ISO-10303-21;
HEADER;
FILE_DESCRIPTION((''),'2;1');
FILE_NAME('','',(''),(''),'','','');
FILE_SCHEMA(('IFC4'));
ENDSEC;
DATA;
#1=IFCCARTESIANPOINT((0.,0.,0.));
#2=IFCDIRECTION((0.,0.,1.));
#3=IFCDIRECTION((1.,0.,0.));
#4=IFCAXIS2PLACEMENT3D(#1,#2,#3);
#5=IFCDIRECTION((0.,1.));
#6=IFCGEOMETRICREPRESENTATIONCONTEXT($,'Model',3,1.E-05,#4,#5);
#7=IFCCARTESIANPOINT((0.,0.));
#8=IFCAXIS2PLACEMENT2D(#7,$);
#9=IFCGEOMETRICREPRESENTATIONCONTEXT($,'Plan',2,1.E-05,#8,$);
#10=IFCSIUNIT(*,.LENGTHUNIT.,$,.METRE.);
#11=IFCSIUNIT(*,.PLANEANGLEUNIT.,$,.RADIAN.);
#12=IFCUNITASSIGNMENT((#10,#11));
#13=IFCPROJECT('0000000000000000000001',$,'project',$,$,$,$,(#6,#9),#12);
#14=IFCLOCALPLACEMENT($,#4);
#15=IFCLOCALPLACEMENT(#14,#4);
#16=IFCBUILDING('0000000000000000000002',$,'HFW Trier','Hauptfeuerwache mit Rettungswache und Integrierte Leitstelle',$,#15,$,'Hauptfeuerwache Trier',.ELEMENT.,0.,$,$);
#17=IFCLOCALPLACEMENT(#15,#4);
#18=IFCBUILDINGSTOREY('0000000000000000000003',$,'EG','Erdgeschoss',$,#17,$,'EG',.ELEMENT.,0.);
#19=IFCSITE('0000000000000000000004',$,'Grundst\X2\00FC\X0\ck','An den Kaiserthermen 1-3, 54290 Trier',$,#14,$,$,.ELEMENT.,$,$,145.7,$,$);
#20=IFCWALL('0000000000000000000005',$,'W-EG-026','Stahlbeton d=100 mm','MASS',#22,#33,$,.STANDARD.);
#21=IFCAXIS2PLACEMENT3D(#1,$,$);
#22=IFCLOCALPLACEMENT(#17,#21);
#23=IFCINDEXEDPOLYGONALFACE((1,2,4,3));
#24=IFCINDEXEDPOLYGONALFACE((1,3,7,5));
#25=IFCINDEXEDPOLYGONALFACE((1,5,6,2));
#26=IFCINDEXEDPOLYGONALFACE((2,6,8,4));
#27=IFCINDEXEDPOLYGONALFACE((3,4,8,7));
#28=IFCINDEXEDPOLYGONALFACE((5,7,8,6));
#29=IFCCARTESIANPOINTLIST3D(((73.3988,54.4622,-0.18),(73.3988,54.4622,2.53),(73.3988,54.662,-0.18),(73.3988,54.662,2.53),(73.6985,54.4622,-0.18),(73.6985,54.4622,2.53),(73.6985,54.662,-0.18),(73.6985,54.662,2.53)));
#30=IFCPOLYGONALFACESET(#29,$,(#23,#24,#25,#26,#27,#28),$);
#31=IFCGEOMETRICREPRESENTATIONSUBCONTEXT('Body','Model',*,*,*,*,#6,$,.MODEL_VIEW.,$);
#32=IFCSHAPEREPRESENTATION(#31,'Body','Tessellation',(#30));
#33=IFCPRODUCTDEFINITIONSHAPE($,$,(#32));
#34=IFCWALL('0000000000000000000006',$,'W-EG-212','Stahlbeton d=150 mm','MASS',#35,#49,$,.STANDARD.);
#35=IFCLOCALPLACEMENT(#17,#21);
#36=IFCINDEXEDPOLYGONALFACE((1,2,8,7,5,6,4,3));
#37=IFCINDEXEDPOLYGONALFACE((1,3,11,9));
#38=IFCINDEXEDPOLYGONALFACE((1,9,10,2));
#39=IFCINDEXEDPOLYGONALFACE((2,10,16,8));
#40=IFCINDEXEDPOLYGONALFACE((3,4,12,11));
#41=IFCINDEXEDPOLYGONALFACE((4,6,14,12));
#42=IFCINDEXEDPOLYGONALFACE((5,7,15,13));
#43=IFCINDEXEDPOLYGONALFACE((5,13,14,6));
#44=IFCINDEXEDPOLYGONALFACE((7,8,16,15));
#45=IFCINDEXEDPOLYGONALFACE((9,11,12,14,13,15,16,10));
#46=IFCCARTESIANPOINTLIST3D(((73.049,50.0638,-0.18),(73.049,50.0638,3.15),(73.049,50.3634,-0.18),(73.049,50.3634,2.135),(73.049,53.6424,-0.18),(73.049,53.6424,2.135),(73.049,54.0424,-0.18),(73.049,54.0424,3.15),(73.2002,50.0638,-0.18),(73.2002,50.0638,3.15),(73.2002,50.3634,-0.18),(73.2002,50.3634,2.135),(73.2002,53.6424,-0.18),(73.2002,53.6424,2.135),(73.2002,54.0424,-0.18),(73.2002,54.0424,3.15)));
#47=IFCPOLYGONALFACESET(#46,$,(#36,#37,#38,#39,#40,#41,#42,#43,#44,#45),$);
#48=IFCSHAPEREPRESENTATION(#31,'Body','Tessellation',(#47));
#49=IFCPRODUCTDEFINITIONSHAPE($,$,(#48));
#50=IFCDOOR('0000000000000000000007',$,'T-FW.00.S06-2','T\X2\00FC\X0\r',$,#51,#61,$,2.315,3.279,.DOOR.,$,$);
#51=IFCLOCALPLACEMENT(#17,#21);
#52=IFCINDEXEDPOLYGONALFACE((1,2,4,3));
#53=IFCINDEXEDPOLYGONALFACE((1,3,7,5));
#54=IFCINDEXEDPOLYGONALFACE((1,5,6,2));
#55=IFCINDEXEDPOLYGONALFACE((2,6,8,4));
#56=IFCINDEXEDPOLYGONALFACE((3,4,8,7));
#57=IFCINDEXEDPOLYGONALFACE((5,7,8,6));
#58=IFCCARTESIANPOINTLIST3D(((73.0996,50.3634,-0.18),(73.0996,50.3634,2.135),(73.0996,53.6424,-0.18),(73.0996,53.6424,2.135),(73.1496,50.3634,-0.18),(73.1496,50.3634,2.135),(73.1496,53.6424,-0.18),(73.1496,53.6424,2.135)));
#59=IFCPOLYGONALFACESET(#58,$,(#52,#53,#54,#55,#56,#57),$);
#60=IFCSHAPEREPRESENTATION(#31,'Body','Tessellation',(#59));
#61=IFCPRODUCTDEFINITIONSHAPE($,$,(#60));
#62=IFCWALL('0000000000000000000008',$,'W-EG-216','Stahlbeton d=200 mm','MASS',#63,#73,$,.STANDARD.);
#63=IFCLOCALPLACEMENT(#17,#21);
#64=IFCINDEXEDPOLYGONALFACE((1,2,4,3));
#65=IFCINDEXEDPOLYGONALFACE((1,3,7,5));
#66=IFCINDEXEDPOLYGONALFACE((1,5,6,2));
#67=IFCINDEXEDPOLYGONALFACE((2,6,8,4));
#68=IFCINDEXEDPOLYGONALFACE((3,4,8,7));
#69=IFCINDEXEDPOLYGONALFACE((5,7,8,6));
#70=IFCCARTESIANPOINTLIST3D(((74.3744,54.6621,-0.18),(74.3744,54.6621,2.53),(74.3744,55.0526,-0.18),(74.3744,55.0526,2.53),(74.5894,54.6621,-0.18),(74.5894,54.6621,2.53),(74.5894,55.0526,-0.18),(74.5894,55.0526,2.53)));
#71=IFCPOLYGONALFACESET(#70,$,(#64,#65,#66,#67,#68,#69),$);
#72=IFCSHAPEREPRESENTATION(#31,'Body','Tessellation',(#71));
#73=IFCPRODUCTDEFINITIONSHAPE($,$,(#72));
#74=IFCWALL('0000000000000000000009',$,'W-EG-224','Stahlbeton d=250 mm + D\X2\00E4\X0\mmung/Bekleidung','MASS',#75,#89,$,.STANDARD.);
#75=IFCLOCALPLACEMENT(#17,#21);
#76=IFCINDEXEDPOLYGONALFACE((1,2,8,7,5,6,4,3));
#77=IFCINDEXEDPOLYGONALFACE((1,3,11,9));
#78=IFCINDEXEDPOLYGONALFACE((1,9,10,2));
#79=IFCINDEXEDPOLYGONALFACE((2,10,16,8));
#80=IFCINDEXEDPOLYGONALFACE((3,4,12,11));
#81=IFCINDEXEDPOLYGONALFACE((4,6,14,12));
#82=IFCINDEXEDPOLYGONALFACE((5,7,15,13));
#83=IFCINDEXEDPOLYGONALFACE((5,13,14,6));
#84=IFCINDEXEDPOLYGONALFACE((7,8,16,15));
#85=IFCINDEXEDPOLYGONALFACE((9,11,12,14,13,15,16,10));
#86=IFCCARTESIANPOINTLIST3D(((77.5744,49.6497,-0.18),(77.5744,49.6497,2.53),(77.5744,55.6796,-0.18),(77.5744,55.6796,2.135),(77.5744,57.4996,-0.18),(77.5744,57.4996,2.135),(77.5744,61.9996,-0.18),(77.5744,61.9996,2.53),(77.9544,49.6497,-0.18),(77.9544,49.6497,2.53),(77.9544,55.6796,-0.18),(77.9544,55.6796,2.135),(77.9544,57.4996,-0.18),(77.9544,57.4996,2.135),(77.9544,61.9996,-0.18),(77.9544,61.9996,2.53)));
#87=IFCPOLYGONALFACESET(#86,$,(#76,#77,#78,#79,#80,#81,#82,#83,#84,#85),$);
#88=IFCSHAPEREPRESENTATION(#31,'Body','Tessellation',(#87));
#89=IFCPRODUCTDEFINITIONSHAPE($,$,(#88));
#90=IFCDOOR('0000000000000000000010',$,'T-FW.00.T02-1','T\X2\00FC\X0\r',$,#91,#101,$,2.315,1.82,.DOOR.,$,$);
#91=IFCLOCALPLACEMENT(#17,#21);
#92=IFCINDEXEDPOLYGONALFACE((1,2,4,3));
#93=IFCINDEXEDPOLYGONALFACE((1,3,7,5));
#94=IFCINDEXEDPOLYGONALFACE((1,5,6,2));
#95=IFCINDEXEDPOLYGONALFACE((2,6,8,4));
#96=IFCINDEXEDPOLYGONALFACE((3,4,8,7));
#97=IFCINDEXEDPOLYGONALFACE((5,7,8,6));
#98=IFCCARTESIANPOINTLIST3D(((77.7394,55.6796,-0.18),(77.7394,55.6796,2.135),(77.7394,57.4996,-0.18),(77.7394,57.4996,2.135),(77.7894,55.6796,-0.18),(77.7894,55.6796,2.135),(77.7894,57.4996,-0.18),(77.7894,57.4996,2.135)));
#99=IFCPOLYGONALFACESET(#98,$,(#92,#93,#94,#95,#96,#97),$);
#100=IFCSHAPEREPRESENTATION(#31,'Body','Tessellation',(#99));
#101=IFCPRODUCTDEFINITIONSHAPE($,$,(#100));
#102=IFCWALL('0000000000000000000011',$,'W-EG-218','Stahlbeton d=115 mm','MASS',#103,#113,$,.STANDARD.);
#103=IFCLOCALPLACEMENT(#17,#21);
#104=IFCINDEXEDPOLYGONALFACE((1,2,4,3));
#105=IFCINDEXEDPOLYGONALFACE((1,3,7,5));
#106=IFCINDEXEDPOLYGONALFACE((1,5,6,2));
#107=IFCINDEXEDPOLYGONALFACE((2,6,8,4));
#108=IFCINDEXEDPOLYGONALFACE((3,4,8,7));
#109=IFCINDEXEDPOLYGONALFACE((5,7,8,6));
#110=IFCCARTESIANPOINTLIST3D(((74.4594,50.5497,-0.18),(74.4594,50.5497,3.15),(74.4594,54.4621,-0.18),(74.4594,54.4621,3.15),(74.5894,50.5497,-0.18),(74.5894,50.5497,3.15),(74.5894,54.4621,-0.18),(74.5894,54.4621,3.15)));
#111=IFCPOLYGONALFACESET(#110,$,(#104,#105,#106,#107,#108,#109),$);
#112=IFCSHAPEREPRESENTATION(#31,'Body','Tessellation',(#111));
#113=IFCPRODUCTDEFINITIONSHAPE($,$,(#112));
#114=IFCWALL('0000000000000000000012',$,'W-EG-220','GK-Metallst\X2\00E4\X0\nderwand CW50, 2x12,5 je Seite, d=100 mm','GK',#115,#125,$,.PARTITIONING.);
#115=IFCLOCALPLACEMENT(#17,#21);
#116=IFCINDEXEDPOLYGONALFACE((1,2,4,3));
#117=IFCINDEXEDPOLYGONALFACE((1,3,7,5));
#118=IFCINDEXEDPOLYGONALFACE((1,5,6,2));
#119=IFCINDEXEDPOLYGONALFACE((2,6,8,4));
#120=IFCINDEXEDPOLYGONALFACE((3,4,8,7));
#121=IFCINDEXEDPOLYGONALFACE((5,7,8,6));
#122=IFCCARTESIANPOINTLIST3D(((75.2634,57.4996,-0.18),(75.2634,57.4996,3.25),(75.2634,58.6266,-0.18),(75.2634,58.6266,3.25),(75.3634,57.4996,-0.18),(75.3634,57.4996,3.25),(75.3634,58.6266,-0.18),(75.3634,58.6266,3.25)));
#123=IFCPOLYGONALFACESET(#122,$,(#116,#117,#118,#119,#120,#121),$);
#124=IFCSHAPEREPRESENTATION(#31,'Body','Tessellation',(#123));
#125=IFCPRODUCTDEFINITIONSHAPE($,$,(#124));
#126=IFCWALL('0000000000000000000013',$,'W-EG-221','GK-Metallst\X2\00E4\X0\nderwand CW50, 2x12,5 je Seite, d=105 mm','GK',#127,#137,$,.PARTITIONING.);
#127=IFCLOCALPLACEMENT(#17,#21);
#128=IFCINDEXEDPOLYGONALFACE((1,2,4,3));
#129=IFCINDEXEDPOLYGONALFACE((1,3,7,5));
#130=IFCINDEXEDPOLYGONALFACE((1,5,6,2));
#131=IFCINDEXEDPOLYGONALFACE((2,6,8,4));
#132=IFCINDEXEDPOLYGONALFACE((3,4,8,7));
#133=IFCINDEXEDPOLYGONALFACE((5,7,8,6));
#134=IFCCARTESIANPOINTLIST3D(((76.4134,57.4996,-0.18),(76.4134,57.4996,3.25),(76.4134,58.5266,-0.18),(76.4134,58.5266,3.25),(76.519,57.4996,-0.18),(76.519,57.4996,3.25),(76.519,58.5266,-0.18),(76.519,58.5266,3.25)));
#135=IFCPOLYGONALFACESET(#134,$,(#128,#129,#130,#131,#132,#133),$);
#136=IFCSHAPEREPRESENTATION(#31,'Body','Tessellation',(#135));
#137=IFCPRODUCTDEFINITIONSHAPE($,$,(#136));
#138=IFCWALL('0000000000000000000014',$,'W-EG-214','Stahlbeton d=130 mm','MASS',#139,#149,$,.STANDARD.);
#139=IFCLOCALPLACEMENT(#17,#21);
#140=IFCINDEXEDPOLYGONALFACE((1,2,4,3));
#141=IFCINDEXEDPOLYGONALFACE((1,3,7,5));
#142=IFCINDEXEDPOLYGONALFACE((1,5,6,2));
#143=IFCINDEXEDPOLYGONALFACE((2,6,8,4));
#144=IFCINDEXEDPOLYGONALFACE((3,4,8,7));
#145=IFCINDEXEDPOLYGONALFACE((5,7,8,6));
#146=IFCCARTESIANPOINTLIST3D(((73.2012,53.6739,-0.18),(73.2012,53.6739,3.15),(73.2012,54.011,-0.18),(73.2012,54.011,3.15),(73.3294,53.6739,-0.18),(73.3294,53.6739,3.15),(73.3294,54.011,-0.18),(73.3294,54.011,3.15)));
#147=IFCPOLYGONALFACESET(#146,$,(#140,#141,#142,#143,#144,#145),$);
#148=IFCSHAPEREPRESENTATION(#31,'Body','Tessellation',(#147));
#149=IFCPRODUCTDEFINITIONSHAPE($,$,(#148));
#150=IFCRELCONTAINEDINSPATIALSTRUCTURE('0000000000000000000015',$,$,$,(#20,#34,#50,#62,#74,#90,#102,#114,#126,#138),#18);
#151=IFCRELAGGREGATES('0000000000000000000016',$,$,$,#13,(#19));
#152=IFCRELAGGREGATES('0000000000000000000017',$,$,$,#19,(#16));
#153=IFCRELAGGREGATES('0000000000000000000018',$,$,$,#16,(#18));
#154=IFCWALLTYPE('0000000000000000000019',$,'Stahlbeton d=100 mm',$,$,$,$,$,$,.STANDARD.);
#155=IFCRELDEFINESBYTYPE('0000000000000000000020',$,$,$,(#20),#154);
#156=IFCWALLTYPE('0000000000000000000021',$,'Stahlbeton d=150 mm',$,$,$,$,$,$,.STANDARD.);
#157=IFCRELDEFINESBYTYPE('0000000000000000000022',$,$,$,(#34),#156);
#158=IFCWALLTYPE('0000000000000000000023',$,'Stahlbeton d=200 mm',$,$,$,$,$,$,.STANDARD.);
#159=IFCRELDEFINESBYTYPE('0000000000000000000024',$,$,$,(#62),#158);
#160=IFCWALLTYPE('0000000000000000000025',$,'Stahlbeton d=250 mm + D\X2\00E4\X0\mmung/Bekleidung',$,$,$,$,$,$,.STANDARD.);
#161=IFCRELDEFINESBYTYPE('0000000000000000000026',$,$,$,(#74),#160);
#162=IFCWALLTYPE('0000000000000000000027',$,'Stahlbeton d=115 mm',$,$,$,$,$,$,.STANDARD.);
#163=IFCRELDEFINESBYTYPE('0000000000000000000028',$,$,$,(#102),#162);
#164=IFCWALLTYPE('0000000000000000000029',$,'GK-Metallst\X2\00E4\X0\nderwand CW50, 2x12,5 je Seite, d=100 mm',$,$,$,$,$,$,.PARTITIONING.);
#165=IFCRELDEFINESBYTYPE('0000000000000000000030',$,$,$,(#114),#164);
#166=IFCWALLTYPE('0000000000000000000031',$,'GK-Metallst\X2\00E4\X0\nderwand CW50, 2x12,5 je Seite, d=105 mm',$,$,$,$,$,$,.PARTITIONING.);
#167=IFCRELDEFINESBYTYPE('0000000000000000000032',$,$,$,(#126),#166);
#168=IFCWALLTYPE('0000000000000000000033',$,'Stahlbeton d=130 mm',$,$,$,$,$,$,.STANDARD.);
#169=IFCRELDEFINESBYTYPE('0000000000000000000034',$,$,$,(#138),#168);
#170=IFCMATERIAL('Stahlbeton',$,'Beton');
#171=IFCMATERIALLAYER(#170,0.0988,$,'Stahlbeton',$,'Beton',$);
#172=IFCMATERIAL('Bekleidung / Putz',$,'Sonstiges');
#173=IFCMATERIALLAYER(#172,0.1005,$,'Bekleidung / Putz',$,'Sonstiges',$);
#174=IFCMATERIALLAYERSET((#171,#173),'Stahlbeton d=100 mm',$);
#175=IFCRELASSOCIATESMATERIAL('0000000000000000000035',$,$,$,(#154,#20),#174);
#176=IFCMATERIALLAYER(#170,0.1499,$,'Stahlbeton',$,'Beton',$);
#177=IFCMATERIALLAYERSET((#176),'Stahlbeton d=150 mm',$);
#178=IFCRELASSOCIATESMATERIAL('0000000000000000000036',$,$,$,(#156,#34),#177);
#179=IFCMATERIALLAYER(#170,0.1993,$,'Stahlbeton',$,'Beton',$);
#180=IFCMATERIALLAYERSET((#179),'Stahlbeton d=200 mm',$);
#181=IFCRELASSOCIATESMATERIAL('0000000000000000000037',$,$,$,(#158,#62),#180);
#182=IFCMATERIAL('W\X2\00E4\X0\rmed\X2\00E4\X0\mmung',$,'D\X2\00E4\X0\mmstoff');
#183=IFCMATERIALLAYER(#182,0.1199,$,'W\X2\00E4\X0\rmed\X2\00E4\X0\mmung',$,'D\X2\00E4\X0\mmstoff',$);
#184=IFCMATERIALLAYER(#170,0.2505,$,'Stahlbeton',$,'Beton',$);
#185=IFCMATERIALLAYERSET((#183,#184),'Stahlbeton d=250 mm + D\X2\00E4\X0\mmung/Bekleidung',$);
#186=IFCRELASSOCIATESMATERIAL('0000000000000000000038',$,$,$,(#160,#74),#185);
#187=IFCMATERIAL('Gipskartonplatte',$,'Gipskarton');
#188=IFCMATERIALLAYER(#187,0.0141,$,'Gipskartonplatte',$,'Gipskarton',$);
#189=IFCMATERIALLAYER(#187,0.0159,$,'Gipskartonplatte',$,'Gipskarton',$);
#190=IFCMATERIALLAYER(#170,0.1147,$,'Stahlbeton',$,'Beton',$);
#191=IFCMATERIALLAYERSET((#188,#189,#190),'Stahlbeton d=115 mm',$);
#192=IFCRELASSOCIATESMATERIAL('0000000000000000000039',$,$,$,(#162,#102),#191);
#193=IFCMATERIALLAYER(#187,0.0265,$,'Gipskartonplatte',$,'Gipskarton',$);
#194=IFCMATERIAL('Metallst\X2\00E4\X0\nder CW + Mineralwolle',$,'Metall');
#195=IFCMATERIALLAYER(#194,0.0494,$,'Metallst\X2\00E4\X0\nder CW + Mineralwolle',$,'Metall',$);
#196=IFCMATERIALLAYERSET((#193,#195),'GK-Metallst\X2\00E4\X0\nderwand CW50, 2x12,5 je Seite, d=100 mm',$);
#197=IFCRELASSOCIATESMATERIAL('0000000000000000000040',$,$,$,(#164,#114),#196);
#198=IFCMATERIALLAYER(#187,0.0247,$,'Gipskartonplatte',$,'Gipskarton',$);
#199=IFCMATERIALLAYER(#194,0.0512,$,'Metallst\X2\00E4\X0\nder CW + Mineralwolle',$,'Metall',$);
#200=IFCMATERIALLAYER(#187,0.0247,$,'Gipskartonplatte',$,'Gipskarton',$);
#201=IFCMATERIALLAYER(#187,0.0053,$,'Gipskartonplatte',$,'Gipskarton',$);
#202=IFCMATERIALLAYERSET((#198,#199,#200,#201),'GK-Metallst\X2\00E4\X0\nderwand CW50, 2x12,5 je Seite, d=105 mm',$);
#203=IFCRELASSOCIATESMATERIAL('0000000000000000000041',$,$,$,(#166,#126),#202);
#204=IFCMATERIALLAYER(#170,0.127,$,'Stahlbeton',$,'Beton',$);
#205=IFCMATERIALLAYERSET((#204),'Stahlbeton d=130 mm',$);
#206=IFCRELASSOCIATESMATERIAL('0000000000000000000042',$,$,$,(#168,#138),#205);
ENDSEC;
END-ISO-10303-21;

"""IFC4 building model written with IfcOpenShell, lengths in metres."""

from ifc_helpers import new_model, si_unit, direction, frame, frame_2d, origin_with_axes, origin_2d, place, context, subcontext, project, spatial, rectangle, extrude, material, layer, layer_set, layer_usage, type_object, element, fill, save


model = new_model("IFC4")

# Units and contexts
model_context = context("Model", 3, precision=1e-05, world=origin_with_axes(), true_north=direction((0.0, 1.0)))
plan_context = context("Plan", 2, precision=1e-05, world=origin_2d())
body_context = subcontext(model_context, "Body", "Model", "MODEL_VIEW")
ifc_project = project(units=[si_unit("LENGTHUNIT", "METRE"), si_unit("PLANEANGLEUNIT", "RADIAN")], contexts=[model_context, plan_context])

# Site, building, storey
site_placement = place(None, origin_with_axes())
site = spatial("IfcSite", under=ifc_project, at=site_placement, Name="Grundstück", Description="An den Kaiserthermen 1-3, 54290 Trier", CompositionType="ELEMENT", RefElevation=145.7)
building_placement = place(site_placement, origin_with_axes())
building = spatial("IfcBuilding", under=site, at=building_placement, Name="HFW Trier", Description="Hauptfeuerwache mit Rettungswache und Integrierte Leitstelle", LongName="Hauptfeuerwache Trier", CompositionType="ELEMENT", ElevationOfRefHeight=0.0)
storey_placement = place(building_placement, origin_with_axes())
storey = spatial("IfcBuildingStorey", under=building, at=storey_placement, Name="EG", Description="Erdgeschoss", LongName="EG", CompositionType="ELEMENT", Elevation=0.0)

# Shared definitions
ifc_material_1 = material(Name="Gipskartonplatte", Category="Gipskarton")
ifc_material_2 = material(Name="Metallständer CW + Mineralwolle", Category="Metall")

# Shared definitions
ifc_material_3 = material(Name="Stahlbeton", Category="Beton")

# Wall
ifc_material_4 = material(Name="Bekleidung / Putz", Category="Sonstiges")
ifc_layer_1 = layer(ifc_material_3, 0.0988, Name="Stahlbeton", Category="Beton")
ifc_layer_2 = layer(ifc_material_4, 0.1005, Name="Bekleidung / Putz", Category="Sonstiges")
ifc_layer_set_1 = layer_set([ifc_layer_1, ifc_layer_2], Name="Stahlbeton d=100 mm")
ifc_layer_usage_1 = layer_usage(ifc_layer_set_1, "AXIS2", "POSITIVE", -0.0999)
wall_type_1 = type_object("IfcWallType", Name="Stahlbeton d=100 mm", PredefinedType="STANDARD", material=ifc_layer_set_1)
wall_1_placement = place(storey_placement, frame((73.3988, 54.5621, -0.18), z_axis=(0.0, 0.0, 1.0), x_axis=(1.0, 0.0, 0.0)))
element("IfcWall", 1, at=wall_1_placement, inside=storey, type_object=wall_type_1, material=ifc_layer_usage_1, Name="W-EG-026", Description="Stahlbeton d=100 mm", ObjectType="MASS", PredefinedType="STANDARD", context=body_context, shape_type="SweptSolid", body=[
    extrude(rectangle(XDim=0.2997, YDim=0.1998, at=frame_2d((0.1499, 0.0))), origin_with_axes(), (0.0, 0.0, 1.0), 2.71),
])

# Wall, opening, door
ifc_layer_3 = layer(ifc_material_3, 0.1499, Name="Stahlbeton", Category="Beton")
ifc_layer_set_2 = layer_set([ifc_layer_3], Name="Stahlbeton d=150 mm")
ifc_layer_usage_2 = layer_usage(ifc_layer_set_2, "AXIS2", "POSITIVE", -0.0756)
wall_type_2 = type_object("IfcWallType", Name="Stahlbeton d=150 mm", PredefinedType="STANDARD", material=ifc_layer_set_2)
wall_2_placement = place(storey_placement, frame((73.1246, 54.0424, -0.18), z_axis=(0.0, 0.0, 1.0), x_axis=(0.0, -1.0, 0.0)))
wall_2 = element("IfcWall", 2, at=wall_2_placement, inside=storey, type_object=wall_type_2, material=ifc_layer_usage_2, Name="W-EG-212", Description="Stahlbeton d=150 mm", ObjectType="MASS", PredefinedType="STANDARD", context=body_context, shape_type="SweptSolid", body=[
    extrude(rectangle(XDim=3.9786, YDim=0.1511, at=frame_2d((1.9893, 0.0))), origin_with_axes(), (0.0, 0.0, 1.0), 3.33),
])
opening_1_placement = place(wall_2_placement, frame((0.4, 0.0, 0.0), z_axis=(0.0, 0.0, 1.0), x_axis=(1.0, 0.0, 0.0)))
opening_1 = element("IfcOpeningElement", 3, at=opening_1_placement, cuts=wall_2, PredefinedType="OPENING", context=body_context, shape_type="SweptSolid", body=[
    extrude(rectangle(XDim=3.279, YDim=0.2511, at=frame_2d((1.6395, 0.0))), origin_with_axes(), (0.0, 0.0, 1.0), 2.315),
])
door_1_placement = place(wall_2_placement, frame((0.4, 0.0, 0.0), z_axis=(0.0, 0.0, 1.0), x_axis=(1.0, 0.0, 0.0)))
door_1 = element("IfcDoor", 4, at=door_1_placement, inside=storey, Name="T-FW.00.S06-2", Description="Tür", OverallHeight=2.315, OverallWidth=3.279, PredefinedType="DOOR", context=body_context, shape_type="SweptSolid", body=[
    extrude(rectangle(XDim=3.279, YDim=0.05, at=frame_2d((1.6395, 0.0))), origin_with_axes(), (0.0, 0.0, 1.0), 2.315),
])
fill(opening_1, door_1)

# Wall
ifc_layer_4 = layer(ifc_material_3, 0.1993, Name="Stahlbeton", Category="Beton")
ifc_layer_set_3 = layer_set([ifc_layer_4], Name="Stahlbeton d=200 mm")
ifc_layer_usage_3 = layer_usage(ifc_layer_set_3, "AXIS2", "POSITIVE", -0.1075)
wall_type_3 = type_object("IfcWallType", Name="Stahlbeton d=200 mm", PredefinedType="STANDARD", material=ifc_layer_set_3)
wall_3_placement = place(storey_placement, frame((74.4819, 55.0526, -0.18), z_axis=(0.0, 0.0, 1.0), x_axis=(0.0, -1.0, 0.0)))
element("IfcWall", 5, at=wall_3_placement, inside=storey, type_object=wall_type_3, material=ifc_layer_usage_3, Name="W-EG-216", Description="Stahlbeton d=200 mm", ObjectType="MASS", PredefinedType="STANDARD", context=body_context, shape_type="SweptSolid", body=[
    extrude(rectangle(XDim=0.3905, YDim=0.215, at=frame_2d((0.1952, 0.0))), origin_with_axes(), (0.0, 0.0, 1.0), 2.71),
])

# Wall, opening, door
ifc_material_5 = material(Name="Wärmedämmung", Category="Dämmstoff")
ifc_layer_5 = layer(ifc_material_5, 0.1199, Name="Wärmedämmung", Category="Dämmstoff")
ifc_layer_6 = layer(ifc_material_3, 0.2505, Name="Stahlbeton", Category="Beton")
ifc_layer_set_4 = layer_set([ifc_layer_5, ifc_layer_6], Name="Stahlbeton d=250 mm + Dämmung/Bekleidung")
ifc_layer_usage_4 = layer_usage(ifc_layer_set_4, "AXIS2", "POSITIVE", -0.19)
wall_type_4 = type_object("IfcWallType", Name="Stahlbeton d=250 mm + Dämmung/Bekleidung", PredefinedType="STANDARD", material=ifc_layer_set_4)
wall_4_placement = place(storey_placement, frame((77.7644, 61.9996, -0.18), z_axis=(0.0, 0.0, 1.0), x_axis=(0.0, -1.0, 0.0)))
wall_4 = element("IfcWall", 6, at=wall_4_placement, inside=storey, type_object=wall_type_4, material=ifc_layer_usage_4, Name="W-EG-224", Description="Stahlbeton d=250 mm + Dämmung/Bekleidung", ObjectType="MASS", PredefinedType="STANDARD", context=body_context, shape_type="SweptSolid", body=[
    extrude(rectangle(XDim=12.3499, YDim=0.38, at=frame_2d((6.1749, 0.0))), origin_with_axes(), (0.0, 0.0, 1.0), 2.71),
])
opening_2_placement = place(wall_4_placement, frame((4.5, 0.0, 0.0), z_axis=(0.0, 0.0, 1.0), x_axis=(1.0, 0.0, 0.0)))
opening_2 = element("IfcOpeningElement", 7, at=opening_2_placement, cuts=wall_4, PredefinedType="OPENING", context=body_context, shape_type="SweptSolid", body=[
    extrude(rectangle(XDim=1.82, YDim=0.48, at=frame_2d((0.91, 0.0))), origin_with_axes(), (0.0, 0.0, 1.0), 2.315),
])
door_2_placement = place(wall_4_placement, frame((4.5, 0.0, 0.0), z_axis=(0.0, 0.0, 1.0), x_axis=(1.0, 0.0, 0.0)))
door_2 = element("IfcDoor", 8, at=door_2_placement, inside=storey, Name="T-FW.00.T02-1", Description="Tür", OverallHeight=2.315, OverallWidth=1.82, PredefinedType="DOOR", context=body_context, shape_type="SweptSolid", body=[
    extrude(rectangle(XDim=1.82, YDim=0.05, at=frame_2d((0.91, 0.0))), origin_with_axes(), (0.0, 0.0, 1.0), 2.315),
])
fill(opening_2, door_2)

# Walls
ifc_layer_7 = layer(ifc_material_1, 0.0141, Name="Gipskartonplatte", Category="Gipskarton")
ifc_layer_8 = layer(ifc_material_1, 0.0159, Name="Gipskartonplatte", Category="Gipskarton")
ifc_layer_9 = layer(ifc_material_3, 0.1147, Name="Stahlbeton", Category="Beton")
ifc_layer_set_5 = layer_set([ifc_layer_7, ifc_layer_8, ifc_layer_9], Name="Stahlbeton d=115 mm")
ifc_layer_usage_5 = layer_usage(ifc_layer_set_5, "AXIS2", "POSITIVE", -0.065)
wall_type_5 = type_object("IfcWallType", Name="Stahlbeton d=115 mm", PredefinedType="STANDARD", material=ifc_layer_set_5)
wall_5_placement = place(storey_placement, frame((74.5244, 54.4621, -0.18), z_axis=(0.0, 0.0, 1.0), x_axis=(0.0, -1.0, 0.0)))
element("IfcWall", 9, at=wall_5_placement, inside=storey, type_object=wall_type_5, material=ifc_layer_usage_5, Name="W-EG-218", Description="Stahlbeton d=115 mm", ObjectType="MASS", PredefinedType="STANDARD", context=body_context, shape_type="SweptSolid", body=[
    extrude(rectangle(XDim=3.9124, YDim=0.13, at=frame_2d((1.9562, 0.0))), origin_with_axes(), (0.0, 0.0, 1.0), 3.33),
])
ifc_layer_10 = layer(ifc_material_1, 0.0265, Name="Gipskartonplatte", Category="Gipskarton")
ifc_layer_11 = layer(ifc_material_2, 0.0494, Name="Metallständer CW + Mineralwolle", Category="Metall")
ifc_layer_set_6 = layer_set([ifc_layer_10, ifc_layer_11], Name="GK-Metallständerwand CW50, 2x12,5 je Seite, d=100 mm")
ifc_layer_usage_6 = layer_usage(ifc_layer_set_6, "AXIS2", "POSITIVE", -0.05)
wall_type_6 = type_object("IfcWallType", Name="GK-Metallständerwand CW50, 2x12,5 je Seite, d=100 mm", PredefinedType="PARTITIONING", material=ifc_layer_set_6)
wall_6_placement = place(storey_placement, frame((75.3134, 58.6266, -0.18), z_axis=(0.0, 0.0, 1.0), x_axis=(0.0, -1.0, 0.0)))
element("IfcWall", 10, at=wall_6_placement, inside=storey, type_object=wall_type_6, material=ifc_layer_usage_6, Name="W-EG-220", Description="GK-Metallständerwand CW50, 2x12,5 je Seite, d=100 mm", ObjectType="GK", PredefinedType="PARTITIONING", context=body_context, shape_type="SweptSolid", body=[
    extrude(rectangle(XDim=1.127, YDim=0.1, at=frame_2d((0.5635, 0.0))), origin_with_axes(), (0.0, 0.0, 1.0), 3.43),
])
ifc_layer_12 = layer(ifc_material_1, 0.0247, Name="Gipskartonplatte", Category="Gipskarton")
ifc_layer_13 = layer(ifc_material_2, 0.0512, Name="Metallständer CW + Mineralwolle", Category="Metall")
ifc_layer_14 = layer(ifc_material_1, 0.0247, Name="Gipskartonplatte", Category="Gipskarton")
ifc_layer_15 = layer(ifc_material_1, 0.0053, Name="Gipskartonplatte", Category="Gipskarton")
ifc_layer_set_7 = layer_set([ifc_layer_12, ifc_layer_13, ifc_layer_14, ifc_layer_15], Name="GK-Metallständerwand CW50, 2x12,5 je Seite, d=105 mm")
ifc_layer_usage_7 = layer_usage(ifc_layer_set_7, "AXIS2", "POSITIVE", -0.0527)
wall_type_7 = type_object("IfcWallType", Name="GK-Metallständerwand CW50, 2x12,5 je Seite, d=105 mm", PredefinedType="PARTITIONING", material=ifc_layer_set_7)
wall_7_placement = place(storey_placement, frame((76.4662, 58.5266, -0.18), z_axis=(0.0, 0.0, 1.0), x_axis=(0.0, -1.0, 0.0)))
element("IfcWall", 11, at=wall_7_placement, inside=storey, type_object=wall_type_7, material=ifc_layer_usage_7, Name="W-EG-221", Description="GK-Metallständerwand CW50, 2x12,5 je Seite, d=105 mm", ObjectType="GK", PredefinedType="PARTITIONING", context=body_context, shape_type="SweptSolid", body=[
    extrude(rectangle(XDim=1.027, YDim=0.1055, at=frame_2d((0.5135, 0.0))), origin_with_axes(), (0.0, 0.0, 1.0), 3.43),
])
ifc_layer_16 = layer(ifc_material_3, 0.127, Name="Stahlbeton", Category="Beton")
ifc_layer_set_8 = layer_set([ifc_layer_16], Name="Stahlbeton d=130 mm")
ifc_layer_usage_8 = layer_usage(ifc_layer_set_8, "AXIS2", "POSITIVE", -0.0641)
wall_type_8 = type_object("IfcWallType", Name="Stahlbeton d=130 mm", PredefinedType="STANDARD", material=ifc_layer_set_8)
wall_8_placement = place(storey_placement, frame((73.2653, 54.011, -0.18), z_axis=(0.0, 0.0, 1.0), x_axis=(0.0, -1.0, 0.0)))
element("IfcWall", 12, at=wall_8_placement, inside=storey, type_object=wall_type_8, material=ifc_layer_usage_8, Name="W-EG-214", Description="Stahlbeton d=130 mm", ObjectType="MASS", PredefinedType="STANDARD", context=body_context, shape_type="SweptSolid", body=[
    extrude(rectangle(XDim=0.3371, YDim=0.1282, at=frame_2d((0.1685, 0.0))), origin_with_axes(), (0.0, 0.0, 1.0), 3.33),
])

save(model, "model.ifc")
